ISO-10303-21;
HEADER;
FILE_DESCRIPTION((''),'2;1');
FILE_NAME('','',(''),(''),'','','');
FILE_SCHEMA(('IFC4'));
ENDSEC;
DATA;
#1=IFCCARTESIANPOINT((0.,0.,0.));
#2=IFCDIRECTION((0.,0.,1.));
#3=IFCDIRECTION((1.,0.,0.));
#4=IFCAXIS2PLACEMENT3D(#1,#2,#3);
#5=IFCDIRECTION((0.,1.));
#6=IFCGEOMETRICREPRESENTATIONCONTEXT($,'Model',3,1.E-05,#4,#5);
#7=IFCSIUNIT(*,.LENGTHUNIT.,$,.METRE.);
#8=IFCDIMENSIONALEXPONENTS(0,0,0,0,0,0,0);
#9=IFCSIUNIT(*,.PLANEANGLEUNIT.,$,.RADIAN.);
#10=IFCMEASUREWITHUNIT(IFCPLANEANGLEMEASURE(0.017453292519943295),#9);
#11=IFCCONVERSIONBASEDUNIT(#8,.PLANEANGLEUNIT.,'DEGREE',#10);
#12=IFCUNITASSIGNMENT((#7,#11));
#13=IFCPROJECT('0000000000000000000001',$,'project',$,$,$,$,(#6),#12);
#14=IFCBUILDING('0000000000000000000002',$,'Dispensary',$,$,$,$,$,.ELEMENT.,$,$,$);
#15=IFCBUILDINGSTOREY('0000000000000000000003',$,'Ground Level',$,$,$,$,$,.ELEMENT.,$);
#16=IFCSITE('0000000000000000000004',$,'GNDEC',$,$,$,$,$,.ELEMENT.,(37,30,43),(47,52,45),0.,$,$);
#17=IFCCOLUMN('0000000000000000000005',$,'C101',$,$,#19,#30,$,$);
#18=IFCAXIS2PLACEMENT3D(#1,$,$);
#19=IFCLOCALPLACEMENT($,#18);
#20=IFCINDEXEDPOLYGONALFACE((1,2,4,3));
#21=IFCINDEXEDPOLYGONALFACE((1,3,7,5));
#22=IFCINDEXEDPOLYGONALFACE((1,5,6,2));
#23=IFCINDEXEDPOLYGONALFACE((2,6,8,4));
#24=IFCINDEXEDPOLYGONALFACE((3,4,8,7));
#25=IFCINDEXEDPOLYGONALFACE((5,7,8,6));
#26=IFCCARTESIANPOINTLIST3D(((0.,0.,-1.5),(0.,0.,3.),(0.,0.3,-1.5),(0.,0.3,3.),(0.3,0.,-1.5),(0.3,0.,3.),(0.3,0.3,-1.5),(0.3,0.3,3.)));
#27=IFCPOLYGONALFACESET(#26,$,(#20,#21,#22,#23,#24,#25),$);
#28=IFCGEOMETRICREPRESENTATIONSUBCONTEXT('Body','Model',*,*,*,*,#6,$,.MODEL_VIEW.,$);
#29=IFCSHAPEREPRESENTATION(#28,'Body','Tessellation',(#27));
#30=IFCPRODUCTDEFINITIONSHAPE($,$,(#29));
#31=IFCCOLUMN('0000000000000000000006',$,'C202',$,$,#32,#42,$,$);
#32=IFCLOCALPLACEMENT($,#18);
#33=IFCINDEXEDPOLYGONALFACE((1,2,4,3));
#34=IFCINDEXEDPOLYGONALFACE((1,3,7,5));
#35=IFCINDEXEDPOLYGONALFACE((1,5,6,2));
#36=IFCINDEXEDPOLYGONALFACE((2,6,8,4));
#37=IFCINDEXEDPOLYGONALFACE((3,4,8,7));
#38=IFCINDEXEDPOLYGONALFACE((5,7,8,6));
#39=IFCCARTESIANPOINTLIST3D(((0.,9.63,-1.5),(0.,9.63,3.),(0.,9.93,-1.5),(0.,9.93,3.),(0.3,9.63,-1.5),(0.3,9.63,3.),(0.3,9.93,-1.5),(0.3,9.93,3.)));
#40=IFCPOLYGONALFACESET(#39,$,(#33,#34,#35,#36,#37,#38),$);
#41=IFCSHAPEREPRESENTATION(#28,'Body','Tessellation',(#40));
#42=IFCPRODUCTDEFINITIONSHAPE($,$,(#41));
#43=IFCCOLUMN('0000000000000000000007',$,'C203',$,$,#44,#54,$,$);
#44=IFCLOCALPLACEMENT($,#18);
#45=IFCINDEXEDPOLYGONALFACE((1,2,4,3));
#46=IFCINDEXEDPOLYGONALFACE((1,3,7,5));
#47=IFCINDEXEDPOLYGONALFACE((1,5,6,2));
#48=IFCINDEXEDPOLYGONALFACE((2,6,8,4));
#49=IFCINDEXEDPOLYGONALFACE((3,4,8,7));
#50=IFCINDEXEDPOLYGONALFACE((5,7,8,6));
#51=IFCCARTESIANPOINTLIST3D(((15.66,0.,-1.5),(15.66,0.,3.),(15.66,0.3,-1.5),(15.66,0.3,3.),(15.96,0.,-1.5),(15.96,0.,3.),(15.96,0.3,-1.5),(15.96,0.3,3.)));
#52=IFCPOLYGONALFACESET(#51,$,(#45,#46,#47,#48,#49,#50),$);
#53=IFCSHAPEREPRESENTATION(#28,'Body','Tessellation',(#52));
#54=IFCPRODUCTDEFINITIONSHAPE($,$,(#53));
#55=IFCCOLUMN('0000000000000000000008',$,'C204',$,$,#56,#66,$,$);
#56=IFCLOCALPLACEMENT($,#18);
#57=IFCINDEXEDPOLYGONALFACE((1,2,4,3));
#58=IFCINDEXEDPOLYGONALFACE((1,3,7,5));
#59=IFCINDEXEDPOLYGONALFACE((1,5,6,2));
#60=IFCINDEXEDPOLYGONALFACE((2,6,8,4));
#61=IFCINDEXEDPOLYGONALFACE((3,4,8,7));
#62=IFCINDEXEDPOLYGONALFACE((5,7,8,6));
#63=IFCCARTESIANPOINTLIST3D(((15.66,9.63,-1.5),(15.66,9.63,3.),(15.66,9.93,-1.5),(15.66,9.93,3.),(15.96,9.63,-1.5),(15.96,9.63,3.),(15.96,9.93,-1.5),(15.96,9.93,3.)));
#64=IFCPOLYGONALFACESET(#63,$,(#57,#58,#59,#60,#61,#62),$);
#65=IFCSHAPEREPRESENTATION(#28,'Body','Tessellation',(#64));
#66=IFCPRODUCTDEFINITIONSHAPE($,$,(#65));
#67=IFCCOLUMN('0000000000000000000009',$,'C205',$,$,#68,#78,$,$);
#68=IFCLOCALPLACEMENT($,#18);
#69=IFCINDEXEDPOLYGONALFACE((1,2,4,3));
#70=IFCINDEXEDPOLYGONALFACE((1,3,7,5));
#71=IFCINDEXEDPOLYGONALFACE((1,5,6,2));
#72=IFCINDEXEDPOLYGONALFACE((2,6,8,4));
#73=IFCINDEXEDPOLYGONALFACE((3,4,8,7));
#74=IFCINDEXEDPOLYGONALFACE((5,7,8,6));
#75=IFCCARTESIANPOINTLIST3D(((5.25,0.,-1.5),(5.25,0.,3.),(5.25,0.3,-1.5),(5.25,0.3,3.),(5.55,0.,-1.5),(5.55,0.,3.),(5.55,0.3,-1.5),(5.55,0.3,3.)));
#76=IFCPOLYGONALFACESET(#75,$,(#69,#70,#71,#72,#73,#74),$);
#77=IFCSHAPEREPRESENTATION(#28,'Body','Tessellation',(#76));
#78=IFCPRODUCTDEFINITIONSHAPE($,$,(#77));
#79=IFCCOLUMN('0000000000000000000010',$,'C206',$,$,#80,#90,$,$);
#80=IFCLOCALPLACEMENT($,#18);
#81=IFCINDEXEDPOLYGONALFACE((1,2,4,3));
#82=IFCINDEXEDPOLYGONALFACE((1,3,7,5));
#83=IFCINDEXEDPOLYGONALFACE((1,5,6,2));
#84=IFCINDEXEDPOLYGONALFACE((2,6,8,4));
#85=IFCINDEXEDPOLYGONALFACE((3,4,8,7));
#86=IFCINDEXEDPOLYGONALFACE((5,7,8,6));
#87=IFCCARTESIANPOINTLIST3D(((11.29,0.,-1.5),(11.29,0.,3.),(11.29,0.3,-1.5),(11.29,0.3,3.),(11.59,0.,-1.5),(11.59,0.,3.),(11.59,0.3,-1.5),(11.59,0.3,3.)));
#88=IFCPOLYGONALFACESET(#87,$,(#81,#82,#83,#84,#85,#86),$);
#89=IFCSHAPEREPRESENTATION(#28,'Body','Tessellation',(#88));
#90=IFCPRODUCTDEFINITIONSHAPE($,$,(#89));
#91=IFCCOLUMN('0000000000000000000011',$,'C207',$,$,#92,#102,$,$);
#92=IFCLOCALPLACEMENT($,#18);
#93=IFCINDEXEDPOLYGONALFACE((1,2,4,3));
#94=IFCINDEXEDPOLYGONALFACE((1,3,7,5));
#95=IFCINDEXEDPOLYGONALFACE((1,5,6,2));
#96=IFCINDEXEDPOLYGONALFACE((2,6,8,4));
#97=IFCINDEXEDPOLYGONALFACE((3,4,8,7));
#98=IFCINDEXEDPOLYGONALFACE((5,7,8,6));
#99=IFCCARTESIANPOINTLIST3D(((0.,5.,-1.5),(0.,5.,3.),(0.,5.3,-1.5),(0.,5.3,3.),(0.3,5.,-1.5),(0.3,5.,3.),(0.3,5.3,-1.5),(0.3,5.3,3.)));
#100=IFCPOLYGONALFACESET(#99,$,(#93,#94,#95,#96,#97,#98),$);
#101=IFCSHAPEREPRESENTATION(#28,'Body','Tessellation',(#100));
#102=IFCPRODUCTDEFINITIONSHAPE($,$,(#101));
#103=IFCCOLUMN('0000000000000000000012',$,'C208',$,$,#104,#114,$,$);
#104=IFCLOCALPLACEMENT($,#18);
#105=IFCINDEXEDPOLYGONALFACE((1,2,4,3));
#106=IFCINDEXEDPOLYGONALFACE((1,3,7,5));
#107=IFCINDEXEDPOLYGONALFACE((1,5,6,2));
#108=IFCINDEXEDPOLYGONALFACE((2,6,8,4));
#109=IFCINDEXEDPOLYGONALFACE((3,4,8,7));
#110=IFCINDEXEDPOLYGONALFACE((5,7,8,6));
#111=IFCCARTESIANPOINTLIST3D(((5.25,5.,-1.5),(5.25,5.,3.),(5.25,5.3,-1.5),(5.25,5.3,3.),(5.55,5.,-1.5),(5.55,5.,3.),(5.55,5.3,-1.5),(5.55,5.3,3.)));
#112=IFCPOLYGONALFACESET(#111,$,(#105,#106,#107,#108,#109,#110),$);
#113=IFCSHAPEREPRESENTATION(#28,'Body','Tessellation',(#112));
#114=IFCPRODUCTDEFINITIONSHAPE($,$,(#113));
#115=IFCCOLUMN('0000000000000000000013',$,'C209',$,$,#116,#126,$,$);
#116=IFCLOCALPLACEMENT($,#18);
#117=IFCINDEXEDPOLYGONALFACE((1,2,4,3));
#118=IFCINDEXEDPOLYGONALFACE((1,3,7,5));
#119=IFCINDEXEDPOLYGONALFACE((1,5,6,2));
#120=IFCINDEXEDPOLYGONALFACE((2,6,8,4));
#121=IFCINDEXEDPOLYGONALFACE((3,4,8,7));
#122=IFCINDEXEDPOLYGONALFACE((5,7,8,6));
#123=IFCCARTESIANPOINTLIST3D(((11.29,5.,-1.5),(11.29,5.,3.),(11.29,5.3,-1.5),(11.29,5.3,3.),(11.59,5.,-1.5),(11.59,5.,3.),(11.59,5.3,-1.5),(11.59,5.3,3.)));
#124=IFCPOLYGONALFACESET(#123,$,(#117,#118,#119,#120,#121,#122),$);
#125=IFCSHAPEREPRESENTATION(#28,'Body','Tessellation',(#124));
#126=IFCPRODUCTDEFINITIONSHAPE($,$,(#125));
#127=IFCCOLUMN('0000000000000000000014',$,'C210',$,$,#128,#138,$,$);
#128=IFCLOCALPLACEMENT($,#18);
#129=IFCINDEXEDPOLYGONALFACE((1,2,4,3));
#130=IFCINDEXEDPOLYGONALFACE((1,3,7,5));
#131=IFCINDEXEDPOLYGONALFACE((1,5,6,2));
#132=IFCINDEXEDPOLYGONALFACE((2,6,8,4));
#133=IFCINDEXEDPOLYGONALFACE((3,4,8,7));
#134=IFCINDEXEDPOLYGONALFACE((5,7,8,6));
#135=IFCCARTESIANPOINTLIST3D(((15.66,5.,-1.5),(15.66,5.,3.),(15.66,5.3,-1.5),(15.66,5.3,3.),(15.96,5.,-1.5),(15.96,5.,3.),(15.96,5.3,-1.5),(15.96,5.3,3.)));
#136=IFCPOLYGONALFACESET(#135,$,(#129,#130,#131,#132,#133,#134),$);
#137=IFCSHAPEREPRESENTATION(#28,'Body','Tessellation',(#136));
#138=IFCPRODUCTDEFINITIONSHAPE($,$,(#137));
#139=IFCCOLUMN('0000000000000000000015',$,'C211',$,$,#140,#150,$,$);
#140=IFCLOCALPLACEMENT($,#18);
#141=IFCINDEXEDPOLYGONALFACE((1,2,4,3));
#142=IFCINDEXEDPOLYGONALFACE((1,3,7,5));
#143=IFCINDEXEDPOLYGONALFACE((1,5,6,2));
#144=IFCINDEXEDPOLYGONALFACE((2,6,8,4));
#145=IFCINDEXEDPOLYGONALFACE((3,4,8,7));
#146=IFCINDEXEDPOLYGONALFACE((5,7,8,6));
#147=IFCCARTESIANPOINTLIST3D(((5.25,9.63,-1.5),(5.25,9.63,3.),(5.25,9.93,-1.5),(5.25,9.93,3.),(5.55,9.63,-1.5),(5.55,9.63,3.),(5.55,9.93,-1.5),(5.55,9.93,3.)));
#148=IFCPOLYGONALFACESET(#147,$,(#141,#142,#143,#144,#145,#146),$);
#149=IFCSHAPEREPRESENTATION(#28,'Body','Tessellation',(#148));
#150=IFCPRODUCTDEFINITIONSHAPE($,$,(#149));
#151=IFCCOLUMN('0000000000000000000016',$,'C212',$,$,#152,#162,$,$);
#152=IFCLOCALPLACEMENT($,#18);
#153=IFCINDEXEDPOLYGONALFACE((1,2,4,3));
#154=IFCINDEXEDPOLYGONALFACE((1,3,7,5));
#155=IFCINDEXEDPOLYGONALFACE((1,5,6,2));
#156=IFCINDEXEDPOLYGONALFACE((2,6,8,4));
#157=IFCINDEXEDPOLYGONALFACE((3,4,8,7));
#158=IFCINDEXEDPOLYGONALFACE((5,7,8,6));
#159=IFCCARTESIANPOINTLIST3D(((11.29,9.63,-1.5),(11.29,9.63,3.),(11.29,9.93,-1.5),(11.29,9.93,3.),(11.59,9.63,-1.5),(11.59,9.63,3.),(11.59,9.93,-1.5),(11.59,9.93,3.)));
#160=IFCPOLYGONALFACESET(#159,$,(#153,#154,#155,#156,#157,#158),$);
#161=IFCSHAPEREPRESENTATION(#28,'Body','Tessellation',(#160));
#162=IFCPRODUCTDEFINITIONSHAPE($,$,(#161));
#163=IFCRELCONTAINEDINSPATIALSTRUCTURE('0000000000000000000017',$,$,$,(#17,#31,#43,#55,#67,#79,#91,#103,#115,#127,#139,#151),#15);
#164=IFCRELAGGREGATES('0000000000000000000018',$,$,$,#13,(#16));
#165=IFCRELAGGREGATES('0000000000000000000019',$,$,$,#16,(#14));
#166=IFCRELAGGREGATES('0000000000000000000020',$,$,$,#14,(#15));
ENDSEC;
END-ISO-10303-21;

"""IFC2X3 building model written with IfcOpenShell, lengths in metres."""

from ifc_helpers import new_model, entity, si_unit, converted_unit, direction, frame, frame_2d, origin_with_axes, place, context, subcontext, project, spatial, rectangle, extrude, element, save


model = new_model("IFC2X3")

# Units and contexts
model_context = context("Model", 3, precision=1e-05, world=origin_with_axes(), true_north=direction((0.0, 1.0)))
body_context = subcontext(model_context, "Body", "Model", "MODEL_VIEW")
ifc_project = project(units=[si_unit("LENGTHUNIT", "METRE"), converted_unit("PLANEANGLEUNIT", "DEGREE", entity("IfcPlaneAngleMeasure", 0.017453292519943295), si_unit("PLANEANGLEUNIT", "RADIAN"), dimensions=[0, 0, 0, 0, 0, 0, 0])], contexts=[model_context])

# Site, building, storey
site = spatial("IfcSite", under=ifc_project, Name="GNDEC", CompositionType="ELEMENT", RefLatitude=(37, 30, 43), RefLongitude=(47, 52, 45), RefElevation=0.0)
building = spatial("IfcBuilding", under=site, Name="Dispensary", CompositionType="ELEMENT")
storey = spatial("IfcBuildingStorey", under=building, Name="Ground Level", CompositionType="ELEMENT")

# Columns
placement = place(None, origin_with_axes())
element("IfcColumn", 1, at=placement, inside=storey, Name="C101", context=body_context, shape_type="SweptSolid", body=[
    extrude(rectangle(XDim=0.3, YDim=0.3, at=frame_2d((0.0, 0.0), x_axis=(1.0, 0.0))), frame((0.15, 0.15, -1.5), z_axis=(0.0, 0.0, 1.0), x_axis=(1.0, 0.0, 0.0)), (0.0, 0.0, 1.0), 4.5),
])
element("IfcColumn", 2, at=placement, inside=storey, Name="C202", context=body_context, shape_type="SweptSolid", body=[
    extrude(rectangle(XDim=0.3, YDim=0.3, at=frame_2d((0.0, 0.0), x_axis=(1.0, 0.0))), frame((0.15, 9.78, -1.5), z_axis=(0.0, 0.0, 1.0), x_axis=(1.0, 0.0, 0.0)), (0.0, 0.0, 1.0), 4.5),
])
element("IfcColumn", 3, at=placement, inside=storey, Name="C203", context=body_context, shape_type="SweptSolid", body=[
    extrude(rectangle(XDim=0.3, YDim=0.3, at=frame_2d((0.0, 0.0), x_axis=(1.0, 0.0))), frame((15.81, 0.15, -1.5), z_axis=(0.0, 0.0, 1.0), x_axis=(1.0, 0.0, 0.0)), (0.0, 0.0, 1.0), 4.5),
])
element("IfcColumn", 4, at=placement, inside=storey, Name="C204", context=body_context, shape_type="SweptSolid", body=[
    extrude(rectangle(XDim=0.3, YDim=0.3, at=frame_2d((0.0, 0.0), x_axis=(1.0, 0.0))), frame((15.81, 9.78, -1.5), z_axis=(0.0, 0.0, 1.0), x_axis=(1.0, 0.0, 0.0)), (0.0, 0.0, 1.0), 4.5),
])
element("IfcColumn", 5, at=placement, inside=storey, Name="C205", context=body_context, shape_type="SweptSolid", body=[
    extrude(rectangle(XDim=0.3, YDim=0.3, at=frame_2d((0.0, 0.0), x_axis=(1.0, 0.0))), frame((5.4, 0.15, -1.5), z_axis=(0.0, 0.0, 1.0), x_axis=(1.0, 0.0, 0.0)), (0.0, 0.0, 1.0), 4.5),
])
element("IfcColumn", 6, at=placement, inside=storey, Name="C206", context=body_context, shape_type="SweptSolid", body=[
    extrude(rectangle(XDim=0.3, YDim=0.3, at=frame_2d((0.0, 0.0), x_axis=(1.0, 0.0))), frame((11.44, 0.15, -1.5), z_axis=(0.0, 0.0, 1.0), x_axis=(1.0, 0.0, 0.0)), (0.0, 0.0, 1.0), 4.5),
])
element("IfcColumn", 7, at=placement, inside=storey, Name="C207", context=body_context, shape_type="SweptSolid", body=[
    extrude(rectangle(XDim=0.3, YDim=0.3, at=frame_2d((0.0, 0.0), x_axis=(1.0, 0.0))), frame((0.15, 5.15, -1.5), z_axis=(0.0, 0.0, 1.0), x_axis=(1.0, 0.0, 0.0)), (0.0, 0.0, 1.0), 4.5),
])
element("IfcColumn", 8, at=placement, inside=storey, Name="C208", context=body_context, shape_type="SweptSolid", body=[
    extrude(rectangle(XDim=0.3, YDim=0.3, at=frame_2d((0.0, 0.0), x_axis=(1.0, 0.0))), frame((5.4, 5.15, -1.5), z_axis=(0.0, 0.0, 1.0), x_axis=(1.0, 0.0, 0.0)), (0.0, 0.0, 1.0), 4.5),
])
element("IfcColumn", 9, at=placement, inside=storey, Name="C209", context=body_context, shape_type="SweptSolid", body=[
    extrude(rectangle(XDim=0.3, YDim=0.3, at=frame_2d((0.0, 0.0), x_axis=(1.0, 0.0))), frame((11.44, 5.15, -1.5), z_axis=(0.0, 0.0, 1.0), x_axis=(1.0, 0.0, 0.0)), (0.0, 0.0, 1.0), 4.5),
])
element("IfcColumn", 10, at=placement, inside=storey, Name="C210", context=body_context, shape_type="SweptSolid", body=[
    extrude(rectangle(XDim=0.3, YDim=0.3, at=frame_2d((0.0, 0.0), x_axis=(1.0, 0.0))), frame((15.81, 5.15, -1.5), z_axis=(0.0, 0.0, 1.0), x_axis=(1.0, 0.0, 0.0)), (0.0, 0.0, 1.0), 4.5),
])
element("IfcColumn", 11, at=placement, inside=storey, Name="C211", context=body_context, shape_type="SweptSolid", body=[
    extrude(rectangle(XDim=0.3, YDim=0.3, at=frame_2d((0.0, 0.0), x_axis=(1.0, 0.0))), frame((5.4, 9.78, -1.5), z_axis=(0.0, 0.0, 1.0), x_axis=(1.0, 0.0, 0.0)), (0.0, 0.0, 1.0), 4.5),
])
element("IfcColumn", 12, at=placement, inside=storey, Name="C212", context=body_context, shape_type="SweptSolid", body=[
    extrude(rectangle(XDim=0.3, YDim=0.3, at=frame_2d((0.0, 0.0), x_axis=(1.0, 0.0))), frame((11.44, 9.78, -1.5), z_axis=(0.0, 0.0, 1.0), x_axis=(1.0, 0.0, 0.0)), (0.0, 0.0, 1.0), 4.5),
])

save(model, "model.ifc")
